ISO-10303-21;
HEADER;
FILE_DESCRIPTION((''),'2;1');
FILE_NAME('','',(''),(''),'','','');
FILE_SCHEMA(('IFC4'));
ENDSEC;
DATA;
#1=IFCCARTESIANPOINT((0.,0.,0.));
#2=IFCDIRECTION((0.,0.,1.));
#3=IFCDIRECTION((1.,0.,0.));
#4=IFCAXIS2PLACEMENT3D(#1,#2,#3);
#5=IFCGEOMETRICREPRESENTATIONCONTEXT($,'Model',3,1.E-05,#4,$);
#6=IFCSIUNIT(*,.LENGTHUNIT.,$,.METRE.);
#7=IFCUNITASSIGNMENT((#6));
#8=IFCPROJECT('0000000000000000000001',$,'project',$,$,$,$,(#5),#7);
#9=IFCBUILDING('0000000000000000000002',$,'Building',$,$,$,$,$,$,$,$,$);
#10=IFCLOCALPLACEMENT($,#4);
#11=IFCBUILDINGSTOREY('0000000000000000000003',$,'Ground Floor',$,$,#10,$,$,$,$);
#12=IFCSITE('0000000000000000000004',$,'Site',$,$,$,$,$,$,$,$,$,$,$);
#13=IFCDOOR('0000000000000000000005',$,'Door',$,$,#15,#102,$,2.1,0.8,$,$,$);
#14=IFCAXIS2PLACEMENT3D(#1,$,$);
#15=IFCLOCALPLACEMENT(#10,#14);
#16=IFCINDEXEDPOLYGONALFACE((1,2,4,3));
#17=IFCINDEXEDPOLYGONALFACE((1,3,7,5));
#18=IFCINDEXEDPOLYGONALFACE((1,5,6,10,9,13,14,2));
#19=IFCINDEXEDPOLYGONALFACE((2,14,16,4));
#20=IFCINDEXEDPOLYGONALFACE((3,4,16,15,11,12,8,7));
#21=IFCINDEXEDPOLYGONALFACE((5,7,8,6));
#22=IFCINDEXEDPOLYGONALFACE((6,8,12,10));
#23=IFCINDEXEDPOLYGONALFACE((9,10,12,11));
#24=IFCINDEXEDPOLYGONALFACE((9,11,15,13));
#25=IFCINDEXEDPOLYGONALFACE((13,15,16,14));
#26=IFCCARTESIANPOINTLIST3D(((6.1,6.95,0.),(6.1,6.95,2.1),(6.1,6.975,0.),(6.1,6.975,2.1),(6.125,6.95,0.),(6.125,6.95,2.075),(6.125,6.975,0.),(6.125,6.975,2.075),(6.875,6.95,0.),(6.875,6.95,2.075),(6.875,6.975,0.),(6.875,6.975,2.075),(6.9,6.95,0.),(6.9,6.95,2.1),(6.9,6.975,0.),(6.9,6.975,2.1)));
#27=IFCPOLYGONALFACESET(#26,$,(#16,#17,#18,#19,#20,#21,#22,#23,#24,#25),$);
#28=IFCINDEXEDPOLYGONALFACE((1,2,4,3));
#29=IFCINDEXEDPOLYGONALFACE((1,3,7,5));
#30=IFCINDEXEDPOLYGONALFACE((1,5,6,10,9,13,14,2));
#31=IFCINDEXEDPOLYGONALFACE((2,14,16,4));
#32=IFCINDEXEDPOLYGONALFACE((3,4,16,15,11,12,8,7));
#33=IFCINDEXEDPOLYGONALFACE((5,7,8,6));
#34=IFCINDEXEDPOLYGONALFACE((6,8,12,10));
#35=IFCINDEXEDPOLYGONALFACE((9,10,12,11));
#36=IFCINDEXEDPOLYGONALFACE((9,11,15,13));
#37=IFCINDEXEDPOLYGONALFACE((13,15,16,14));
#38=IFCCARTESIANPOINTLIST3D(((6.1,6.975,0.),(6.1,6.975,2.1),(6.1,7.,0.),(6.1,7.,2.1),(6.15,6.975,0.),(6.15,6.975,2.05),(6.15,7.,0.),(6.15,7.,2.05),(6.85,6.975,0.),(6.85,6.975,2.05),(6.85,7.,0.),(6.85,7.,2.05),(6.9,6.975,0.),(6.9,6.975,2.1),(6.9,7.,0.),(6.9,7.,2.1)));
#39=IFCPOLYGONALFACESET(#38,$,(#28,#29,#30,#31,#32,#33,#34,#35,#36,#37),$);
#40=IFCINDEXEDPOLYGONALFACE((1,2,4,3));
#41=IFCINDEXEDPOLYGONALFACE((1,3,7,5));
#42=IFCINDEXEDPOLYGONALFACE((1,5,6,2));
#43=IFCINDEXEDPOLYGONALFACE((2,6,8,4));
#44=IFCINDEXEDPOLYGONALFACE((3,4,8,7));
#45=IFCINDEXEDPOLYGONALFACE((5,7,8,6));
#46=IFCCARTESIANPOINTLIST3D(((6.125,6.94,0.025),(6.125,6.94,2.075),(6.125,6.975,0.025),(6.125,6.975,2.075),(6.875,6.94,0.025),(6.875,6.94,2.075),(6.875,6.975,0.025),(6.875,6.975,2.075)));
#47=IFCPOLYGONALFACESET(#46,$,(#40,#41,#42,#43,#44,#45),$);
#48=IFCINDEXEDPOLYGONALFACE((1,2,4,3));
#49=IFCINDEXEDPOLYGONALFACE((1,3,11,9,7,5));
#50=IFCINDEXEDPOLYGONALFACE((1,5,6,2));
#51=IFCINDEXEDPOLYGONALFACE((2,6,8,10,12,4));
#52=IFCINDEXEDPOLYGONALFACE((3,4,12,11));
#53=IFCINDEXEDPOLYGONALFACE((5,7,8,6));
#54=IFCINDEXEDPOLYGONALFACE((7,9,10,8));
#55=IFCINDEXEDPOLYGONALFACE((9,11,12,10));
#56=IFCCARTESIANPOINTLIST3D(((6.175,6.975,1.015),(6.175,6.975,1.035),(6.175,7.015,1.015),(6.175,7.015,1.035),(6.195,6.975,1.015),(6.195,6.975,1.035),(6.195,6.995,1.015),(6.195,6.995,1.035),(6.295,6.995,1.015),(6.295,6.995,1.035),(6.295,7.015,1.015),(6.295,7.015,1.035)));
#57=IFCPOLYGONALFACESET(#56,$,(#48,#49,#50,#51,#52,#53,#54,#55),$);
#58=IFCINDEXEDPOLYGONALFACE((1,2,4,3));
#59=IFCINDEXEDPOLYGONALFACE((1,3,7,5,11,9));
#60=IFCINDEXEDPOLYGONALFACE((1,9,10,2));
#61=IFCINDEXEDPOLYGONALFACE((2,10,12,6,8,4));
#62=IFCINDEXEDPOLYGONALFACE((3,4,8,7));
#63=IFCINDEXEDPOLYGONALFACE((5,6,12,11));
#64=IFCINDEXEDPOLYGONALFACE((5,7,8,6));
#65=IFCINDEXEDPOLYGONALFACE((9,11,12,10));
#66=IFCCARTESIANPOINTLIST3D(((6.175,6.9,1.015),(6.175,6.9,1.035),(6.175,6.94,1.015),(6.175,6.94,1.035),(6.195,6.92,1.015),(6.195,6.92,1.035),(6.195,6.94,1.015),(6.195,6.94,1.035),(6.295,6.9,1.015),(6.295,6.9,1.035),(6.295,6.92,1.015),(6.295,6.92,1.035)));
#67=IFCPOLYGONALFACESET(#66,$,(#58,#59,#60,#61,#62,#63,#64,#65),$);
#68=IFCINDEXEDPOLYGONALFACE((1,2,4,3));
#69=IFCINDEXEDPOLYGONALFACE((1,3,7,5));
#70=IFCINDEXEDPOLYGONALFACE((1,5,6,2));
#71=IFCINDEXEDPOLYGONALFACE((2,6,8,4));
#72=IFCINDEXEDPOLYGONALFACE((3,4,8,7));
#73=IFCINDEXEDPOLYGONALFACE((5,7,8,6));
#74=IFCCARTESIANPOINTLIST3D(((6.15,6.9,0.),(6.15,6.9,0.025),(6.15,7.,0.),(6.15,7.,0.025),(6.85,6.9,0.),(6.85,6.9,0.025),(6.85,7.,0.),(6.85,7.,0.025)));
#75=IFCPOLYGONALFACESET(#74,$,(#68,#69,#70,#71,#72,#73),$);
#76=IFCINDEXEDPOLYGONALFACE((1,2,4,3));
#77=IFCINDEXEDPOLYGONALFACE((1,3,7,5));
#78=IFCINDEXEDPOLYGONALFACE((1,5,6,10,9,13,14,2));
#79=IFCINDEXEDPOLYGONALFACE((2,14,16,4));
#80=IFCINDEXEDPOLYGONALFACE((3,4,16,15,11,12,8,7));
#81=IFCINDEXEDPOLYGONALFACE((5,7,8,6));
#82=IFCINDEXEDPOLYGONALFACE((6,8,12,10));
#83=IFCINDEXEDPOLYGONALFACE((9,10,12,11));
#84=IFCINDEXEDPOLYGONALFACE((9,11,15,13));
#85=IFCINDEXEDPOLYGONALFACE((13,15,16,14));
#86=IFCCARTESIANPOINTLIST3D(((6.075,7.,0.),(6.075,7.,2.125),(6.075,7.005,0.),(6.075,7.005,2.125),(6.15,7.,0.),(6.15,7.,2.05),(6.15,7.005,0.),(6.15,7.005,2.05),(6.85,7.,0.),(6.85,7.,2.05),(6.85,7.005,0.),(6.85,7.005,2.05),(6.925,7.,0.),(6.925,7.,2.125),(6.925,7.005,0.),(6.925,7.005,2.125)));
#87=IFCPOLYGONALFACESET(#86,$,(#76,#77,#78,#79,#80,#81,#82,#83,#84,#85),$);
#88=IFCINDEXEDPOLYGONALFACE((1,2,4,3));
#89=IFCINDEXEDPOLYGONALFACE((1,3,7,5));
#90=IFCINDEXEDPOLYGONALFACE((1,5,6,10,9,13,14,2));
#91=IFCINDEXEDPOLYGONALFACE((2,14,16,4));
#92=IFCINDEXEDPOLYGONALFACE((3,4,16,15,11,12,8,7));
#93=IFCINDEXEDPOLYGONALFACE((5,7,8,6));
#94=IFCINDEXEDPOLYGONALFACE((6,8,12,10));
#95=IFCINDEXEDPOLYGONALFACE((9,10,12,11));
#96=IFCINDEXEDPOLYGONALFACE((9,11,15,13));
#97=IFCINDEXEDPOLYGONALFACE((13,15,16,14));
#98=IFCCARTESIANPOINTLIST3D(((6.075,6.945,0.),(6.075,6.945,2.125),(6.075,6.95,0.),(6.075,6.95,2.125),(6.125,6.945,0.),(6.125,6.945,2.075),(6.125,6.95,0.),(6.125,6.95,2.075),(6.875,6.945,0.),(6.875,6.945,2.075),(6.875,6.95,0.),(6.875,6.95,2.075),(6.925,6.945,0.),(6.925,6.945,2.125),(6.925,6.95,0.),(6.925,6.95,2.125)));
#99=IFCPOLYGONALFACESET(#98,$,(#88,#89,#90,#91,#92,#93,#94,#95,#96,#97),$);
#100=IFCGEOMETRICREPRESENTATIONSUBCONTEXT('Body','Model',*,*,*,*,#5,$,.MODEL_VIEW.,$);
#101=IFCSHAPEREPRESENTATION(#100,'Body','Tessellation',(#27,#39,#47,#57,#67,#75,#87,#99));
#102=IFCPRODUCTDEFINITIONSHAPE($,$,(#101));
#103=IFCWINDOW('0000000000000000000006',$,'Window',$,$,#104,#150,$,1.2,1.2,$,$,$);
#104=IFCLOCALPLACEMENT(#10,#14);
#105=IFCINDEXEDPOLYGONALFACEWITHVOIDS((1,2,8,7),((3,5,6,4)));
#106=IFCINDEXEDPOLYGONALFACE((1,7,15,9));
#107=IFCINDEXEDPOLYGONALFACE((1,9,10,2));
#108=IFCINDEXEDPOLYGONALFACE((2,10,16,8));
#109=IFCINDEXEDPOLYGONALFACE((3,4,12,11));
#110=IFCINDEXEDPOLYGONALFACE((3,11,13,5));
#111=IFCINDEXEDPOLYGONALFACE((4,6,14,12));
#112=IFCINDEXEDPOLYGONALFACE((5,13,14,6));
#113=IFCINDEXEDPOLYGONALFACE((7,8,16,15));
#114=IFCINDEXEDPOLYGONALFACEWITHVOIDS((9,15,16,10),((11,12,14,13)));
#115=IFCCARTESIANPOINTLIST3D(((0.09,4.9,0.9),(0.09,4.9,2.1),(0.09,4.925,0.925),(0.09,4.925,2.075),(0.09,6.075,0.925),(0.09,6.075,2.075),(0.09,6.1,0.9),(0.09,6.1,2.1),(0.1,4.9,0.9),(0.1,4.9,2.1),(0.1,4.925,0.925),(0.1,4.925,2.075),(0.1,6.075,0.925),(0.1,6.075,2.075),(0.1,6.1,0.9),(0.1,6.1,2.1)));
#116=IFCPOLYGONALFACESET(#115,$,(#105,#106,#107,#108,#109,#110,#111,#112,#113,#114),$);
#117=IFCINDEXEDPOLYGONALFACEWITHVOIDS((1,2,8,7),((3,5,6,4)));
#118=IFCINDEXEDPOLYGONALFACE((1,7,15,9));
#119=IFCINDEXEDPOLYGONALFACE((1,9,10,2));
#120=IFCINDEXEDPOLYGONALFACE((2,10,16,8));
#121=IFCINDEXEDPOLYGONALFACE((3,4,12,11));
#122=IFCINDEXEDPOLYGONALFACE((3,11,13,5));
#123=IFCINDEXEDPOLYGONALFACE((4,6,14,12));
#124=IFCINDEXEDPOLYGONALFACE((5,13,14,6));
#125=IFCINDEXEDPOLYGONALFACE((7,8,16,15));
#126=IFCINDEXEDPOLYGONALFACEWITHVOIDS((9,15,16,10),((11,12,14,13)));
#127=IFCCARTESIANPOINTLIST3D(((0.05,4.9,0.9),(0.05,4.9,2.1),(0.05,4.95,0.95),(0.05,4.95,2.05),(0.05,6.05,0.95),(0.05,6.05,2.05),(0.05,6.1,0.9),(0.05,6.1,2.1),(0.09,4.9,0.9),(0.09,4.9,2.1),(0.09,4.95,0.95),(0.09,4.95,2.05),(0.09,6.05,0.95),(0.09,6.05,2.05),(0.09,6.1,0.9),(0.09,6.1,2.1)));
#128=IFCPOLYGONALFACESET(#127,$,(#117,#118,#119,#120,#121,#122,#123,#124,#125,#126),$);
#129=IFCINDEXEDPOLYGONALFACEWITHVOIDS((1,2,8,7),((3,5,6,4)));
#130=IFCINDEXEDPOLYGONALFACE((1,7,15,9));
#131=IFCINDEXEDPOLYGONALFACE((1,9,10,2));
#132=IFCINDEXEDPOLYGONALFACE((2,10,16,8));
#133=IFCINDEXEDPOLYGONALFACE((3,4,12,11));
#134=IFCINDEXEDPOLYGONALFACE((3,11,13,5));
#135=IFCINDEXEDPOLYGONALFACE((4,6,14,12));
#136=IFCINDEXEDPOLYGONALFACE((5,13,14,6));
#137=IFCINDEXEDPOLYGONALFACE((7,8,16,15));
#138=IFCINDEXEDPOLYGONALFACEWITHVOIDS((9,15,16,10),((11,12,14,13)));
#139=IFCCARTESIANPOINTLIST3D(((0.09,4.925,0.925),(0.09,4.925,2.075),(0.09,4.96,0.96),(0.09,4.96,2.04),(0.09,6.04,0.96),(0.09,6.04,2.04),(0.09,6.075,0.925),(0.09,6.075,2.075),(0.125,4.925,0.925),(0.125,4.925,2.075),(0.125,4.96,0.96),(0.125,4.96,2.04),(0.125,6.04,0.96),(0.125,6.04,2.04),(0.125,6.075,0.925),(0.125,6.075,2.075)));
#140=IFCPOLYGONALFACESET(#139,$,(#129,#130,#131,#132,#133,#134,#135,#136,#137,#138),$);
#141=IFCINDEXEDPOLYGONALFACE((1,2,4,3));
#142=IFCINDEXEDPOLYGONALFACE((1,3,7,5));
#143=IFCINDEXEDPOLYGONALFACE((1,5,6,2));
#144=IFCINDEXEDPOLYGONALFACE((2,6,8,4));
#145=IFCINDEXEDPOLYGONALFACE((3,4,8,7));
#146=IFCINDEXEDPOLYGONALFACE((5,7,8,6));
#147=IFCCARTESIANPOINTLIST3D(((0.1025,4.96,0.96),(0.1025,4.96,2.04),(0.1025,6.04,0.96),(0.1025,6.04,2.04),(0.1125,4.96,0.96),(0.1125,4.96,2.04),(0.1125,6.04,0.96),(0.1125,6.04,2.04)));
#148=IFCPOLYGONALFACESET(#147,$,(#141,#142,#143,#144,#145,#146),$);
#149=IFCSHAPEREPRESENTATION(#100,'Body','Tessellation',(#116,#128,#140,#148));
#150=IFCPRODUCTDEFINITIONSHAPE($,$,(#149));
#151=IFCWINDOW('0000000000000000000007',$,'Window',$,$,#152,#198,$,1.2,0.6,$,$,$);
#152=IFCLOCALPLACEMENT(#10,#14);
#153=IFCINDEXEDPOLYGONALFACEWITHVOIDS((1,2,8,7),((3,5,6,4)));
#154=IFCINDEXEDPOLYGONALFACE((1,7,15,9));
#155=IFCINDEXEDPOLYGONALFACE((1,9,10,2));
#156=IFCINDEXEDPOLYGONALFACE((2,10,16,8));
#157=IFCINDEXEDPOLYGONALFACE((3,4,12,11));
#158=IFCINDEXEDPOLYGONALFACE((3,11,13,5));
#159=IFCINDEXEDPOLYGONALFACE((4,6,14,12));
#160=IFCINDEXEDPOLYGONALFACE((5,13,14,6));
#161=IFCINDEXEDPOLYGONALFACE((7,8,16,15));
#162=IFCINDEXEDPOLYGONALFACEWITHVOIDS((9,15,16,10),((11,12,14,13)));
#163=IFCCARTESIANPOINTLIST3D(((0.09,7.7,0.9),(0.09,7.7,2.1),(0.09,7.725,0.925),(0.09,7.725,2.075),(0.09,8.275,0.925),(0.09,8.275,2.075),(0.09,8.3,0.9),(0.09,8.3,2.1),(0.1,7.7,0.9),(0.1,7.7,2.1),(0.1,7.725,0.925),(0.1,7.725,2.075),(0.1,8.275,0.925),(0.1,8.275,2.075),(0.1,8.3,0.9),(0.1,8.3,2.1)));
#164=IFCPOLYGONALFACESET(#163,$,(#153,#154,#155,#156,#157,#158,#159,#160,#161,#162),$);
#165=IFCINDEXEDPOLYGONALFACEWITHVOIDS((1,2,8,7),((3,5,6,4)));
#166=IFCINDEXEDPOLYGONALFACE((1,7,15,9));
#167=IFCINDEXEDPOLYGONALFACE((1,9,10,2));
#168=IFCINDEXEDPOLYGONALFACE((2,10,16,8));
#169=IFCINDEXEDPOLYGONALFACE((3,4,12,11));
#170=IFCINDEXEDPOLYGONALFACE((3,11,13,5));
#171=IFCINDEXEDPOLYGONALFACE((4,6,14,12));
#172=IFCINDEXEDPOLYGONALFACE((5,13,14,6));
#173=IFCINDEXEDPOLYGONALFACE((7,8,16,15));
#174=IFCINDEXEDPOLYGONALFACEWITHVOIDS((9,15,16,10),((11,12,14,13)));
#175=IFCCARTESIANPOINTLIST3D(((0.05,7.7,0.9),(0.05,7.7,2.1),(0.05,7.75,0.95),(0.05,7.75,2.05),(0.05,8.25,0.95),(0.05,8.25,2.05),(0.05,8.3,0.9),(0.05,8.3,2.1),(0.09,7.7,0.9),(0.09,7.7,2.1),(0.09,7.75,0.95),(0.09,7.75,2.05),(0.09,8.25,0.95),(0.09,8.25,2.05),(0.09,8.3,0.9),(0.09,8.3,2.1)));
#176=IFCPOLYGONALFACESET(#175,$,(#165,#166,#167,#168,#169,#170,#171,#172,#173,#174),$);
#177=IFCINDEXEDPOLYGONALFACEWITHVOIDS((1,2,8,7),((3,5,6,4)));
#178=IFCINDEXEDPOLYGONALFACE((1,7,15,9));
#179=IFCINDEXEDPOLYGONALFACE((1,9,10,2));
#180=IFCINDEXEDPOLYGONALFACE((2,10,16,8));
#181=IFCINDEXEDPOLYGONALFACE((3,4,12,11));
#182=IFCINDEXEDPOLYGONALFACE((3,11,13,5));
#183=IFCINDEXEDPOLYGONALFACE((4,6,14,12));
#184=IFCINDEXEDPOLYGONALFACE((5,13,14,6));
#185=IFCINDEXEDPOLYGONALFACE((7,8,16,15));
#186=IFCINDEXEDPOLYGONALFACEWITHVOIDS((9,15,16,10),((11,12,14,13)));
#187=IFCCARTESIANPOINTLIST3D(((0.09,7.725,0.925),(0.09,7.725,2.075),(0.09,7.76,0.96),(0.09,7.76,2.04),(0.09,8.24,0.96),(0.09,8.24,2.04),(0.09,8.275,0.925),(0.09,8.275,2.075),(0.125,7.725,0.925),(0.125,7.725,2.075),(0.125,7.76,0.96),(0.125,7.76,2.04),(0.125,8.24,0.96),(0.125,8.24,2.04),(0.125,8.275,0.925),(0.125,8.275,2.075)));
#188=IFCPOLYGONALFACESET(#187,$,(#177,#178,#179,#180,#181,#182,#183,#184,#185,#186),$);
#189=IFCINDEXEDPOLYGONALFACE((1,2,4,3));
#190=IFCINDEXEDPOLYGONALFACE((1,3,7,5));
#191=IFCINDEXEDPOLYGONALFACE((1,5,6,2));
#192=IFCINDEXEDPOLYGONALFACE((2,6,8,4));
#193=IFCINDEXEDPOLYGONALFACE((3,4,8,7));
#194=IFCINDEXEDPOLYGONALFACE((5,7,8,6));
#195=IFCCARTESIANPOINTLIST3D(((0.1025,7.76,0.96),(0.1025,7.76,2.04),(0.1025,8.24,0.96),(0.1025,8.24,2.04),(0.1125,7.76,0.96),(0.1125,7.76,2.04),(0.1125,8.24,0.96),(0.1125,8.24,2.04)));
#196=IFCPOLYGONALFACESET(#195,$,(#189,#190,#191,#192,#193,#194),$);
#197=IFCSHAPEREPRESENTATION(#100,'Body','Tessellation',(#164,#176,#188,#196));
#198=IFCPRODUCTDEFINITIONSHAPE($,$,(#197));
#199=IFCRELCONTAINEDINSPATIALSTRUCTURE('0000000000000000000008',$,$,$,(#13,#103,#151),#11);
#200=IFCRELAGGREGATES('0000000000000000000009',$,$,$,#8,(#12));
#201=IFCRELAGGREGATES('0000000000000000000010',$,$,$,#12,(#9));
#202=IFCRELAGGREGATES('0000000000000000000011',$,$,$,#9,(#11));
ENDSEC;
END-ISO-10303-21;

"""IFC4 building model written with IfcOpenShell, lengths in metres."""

from ifc_helpers import new_model, si_unit, frame, origin_with_axes, place, context, subcontext, project, spatial, line, indexed_curve, outline, extrude, element, save


model = new_model("IFC4")

# Units and contexts
model_context = context("Model", 3, precision=1e-05, world=origin_with_axes())
body_context = subcontext(model_context, "Body", "Model", "MODEL_VIEW")
ifc_project = project(units=[si_unit("LENGTHUNIT", "METRE")], contexts=[model_context])

# Site, building, storey
site = spatial("IfcSite", under=ifc_project, Name="Site")
building = spatial("IfcBuilding", under=site, Name="Building")
storey_placement = place(None, origin_with_axes())
storey = spatial("IfcBuildingStorey", under=building, at=storey_placement, Name="Ground Floor")

# Door
door_1_placement = place(storey_placement, frame((6.9, 7.0, 0.0), z_axis=(0.0, 0.0, 1.0), x_axis=(-1.0, 0.0, 0.0)))
element("IfcDoor", 1, at=door_1_placement, inside=storey, Name="Door", OverallHeight=2.1, OverallWidth=0.8, context=body_context, shape_type="SweptSolid", body=[
    extrude(outline(indexed_curve([(0.0, 0.0), (0.0, 2.1), (0.8, 2.1), (0.8, 0.0), (0.775, 0.0), (0.775, 2.075), (0.025, 2.075), (0.025, 0.0)], segments=[line(1, 2, 3, 4, 5, 6, 7, 8, 1)])), frame((0.0, 0.025, 0.0), z_axis=(0.0, -1.0, 0.0), x_axis=(1.0, 0.0, 0.0)), (0.0, 0.0, -1.0), 0.025),
    extrude(outline(indexed_curve([(0.0, 0.0), (0.0, 2.1), (0.8, 2.1), (0.8, 0.0), (0.75, 0.0), (0.75, 2.05), (0.05, 2.05), (0.05, 0.0)], segments=[line(1, 2, 3, 4, 5, 6, 7, 8, 1)])), frame((0.0, 0.0, 0.0), z_axis=(0.0, -1.0, 0.0), x_axis=(1.0, 0.0, 0.0)), (0.0, 0.0, -1.0), 0.025),
    extrude(outline(indexed_curve([(0.0, 0.0), (0.75, 0.0), (0.75, 0.035), (0.0, 0.035)], segments=[line(1, 2, 3, 4, 1)])), frame((0.025, 0.025, 0.025), z_axis=(0.0, 0.0, 1.0), x_axis=(1.0, 0.0, 0.0)), (0.0, 0.0, 1.0), 2.05),
    extrude(outline(indexed_curve([(0.0, 0.0), (0.0, -0.04), (-0.12, -0.04), (-0.12, -0.02), (-0.02, -0.02), (-0.02, 0.0)], segments=[line(1, 2, 3, 4, 5, 6, 1)])), frame((0.725, 0.025, 1.015), z_axis=(0.0, 0.0, 1.0), x_axis=(1.0, 0.0, 0.0)), (0.0, 0.0, 1.0), 0.02),
    extrude(outline(indexed_curve([(0.0, 0.0), (0.0, 0.04), (-0.12, 0.04), (-0.12, 0.02), (-0.02, 0.02), (-0.02, 0.0)], segments=[line(1, 2, 3, 4, 5, 6, 1)])), frame((0.725, 0.06, 1.015), z_axis=(0.0, 0.0, 1.0), x_axis=(1.0, 0.0, 0.0)), (0.0, 0.0, 1.0), 0.02),
    extrude(outline(indexed_curve([(0.0, 0.0), (0.7, 0.0), (0.7, 0.1), (0.0, 0.1)], segments=[line(1, 2, 3, 4, 1)])), frame((0.05, 0.0, 0.0), z_axis=(0.0, 0.0, 1.0), x_axis=(1.0, 0.0, 0.0)), (0.0, 0.0, 1.0), 0.025),
    extrude(outline(indexed_curve([(0.0, 0.0), (0.0, 2.125), (0.85, 2.125), (0.85, 0.0), (0.775, 0.0), (0.775, 2.05), (0.075, 2.05), (0.075, 0.0)], segments=[line(1, 2, 3, 4, 5, 6, 7, 8, 1)])), frame((-0.025, -0.005, 0.0), z_axis=(0.0, -1.0, 0.0), x_axis=(1.0, 0.0, 0.0)), (0.0, 0.0, -1.0), 0.005),
    extrude(outline(indexed_curve([(0.0, 0.0), (0.0, 2.125), (0.85, 2.125), (0.85, 0.0), (0.8, 0.0), (0.8, 2.075), (0.05, 2.075), (0.05, 0.0)], segments=[line(1, 2, 3, 4, 5, 6, 7, 8, 1)])), frame((-0.025, 0.05, 0.0), z_axis=(0.0, -1.0, 0.0), x_axis=(1.0, 0.0, 0.0)), (0.0, 0.0, -1.0), 0.005),
])

# Windows
window_1_placement = place(storey_placement, frame((0.0, 6.1, 0.9), z_axis=(0.0, 0.0, 1.0), x_axis=(0.0, -1.0, 0.0)))
element("IfcWindow", 2, at=window_1_placement, inside=storey, Name="Window", OverallHeight=1.2, OverallWidth=1.2, context=body_context, shape_type="SweptSolid", body=[
    extrude(outline(indexed_curve([(0.0, 0.0), (1.2, 0.0), (1.2, 1.2), (0.0, 1.2)], segments=[line(1, 2, 3, 4, 1)]), holes=[indexed_curve([(0.025, 0.025), (1.175, 0.025), (1.175, 1.175), (0.025, 1.175)], segments=[line(1, 2, 3, 4, 1)])]), frame((0.0, 0.09, 0.0), z_axis=(0.0, -1.0, 0.0), x_axis=(1.0, 0.0, 0.0)), (0.0, 0.0, -1.0), 0.01),
    extrude(outline(indexed_curve([(0.0, 0.0), (1.2, 0.0), (1.2, 1.2), (0.0, 1.2)], segments=[line(1, 2, 3, 4, 1)]), holes=[indexed_curve([(0.05, 0.05), (1.15, 0.05), (1.15, 1.15), (0.05, 1.15)], segments=[line(1, 2, 3, 4, 1)])]), frame((0.0, 0.05, 0.0), z_axis=(0.0, -1.0, 0.0), x_axis=(1.0, 0.0, 0.0)), (0.0, 0.0, -1.0), 0.04),
    extrude(outline(indexed_curve([(0.0, 0.0), (1.15, 0.0), (1.15, 1.15), (0.0, 1.15)], segments=[line(1, 2, 3, 4, 1)]), holes=[indexed_curve([(0.035, 0.035), (1.115, 0.035), (1.115, 1.115), (0.035, 1.115)], segments=[line(1, 2, 3, 4, 1)])]), frame((0.025, 0.09, 0.025), z_axis=(0.0, -1.0, 0.0), x_axis=(1.0, 0.0, 0.0)), (0.0, 0.0, -1.0), 0.035),
    extrude(outline(indexed_curve([(0.035, 0.035), (1.115, 0.035), (1.115, 1.115), (0.035, 1.115)], segments=[line(1, 2, 3, 4, 1)])), frame((0.025, 0.1025, 0.025), z_axis=(0.0, -1.0, 0.0), x_axis=(1.0, 0.0, 0.0)), (0.0, 0.0, -1.0), 0.01),
])
window_2_placement = place(storey_placement, frame((0.0, 8.3, 0.9), z_axis=(0.0, 0.0, 1.0), x_axis=(0.0, -1.0, 0.0)))
element("IfcWindow", 3, at=window_2_placement, inside=storey, Name="Window", OverallHeight=1.2, OverallWidth=0.6, context=body_context, shape_type="SweptSolid", body=[
    extrude(outline(indexed_curve([(0.0, 0.0), (0.6, 0.0), (0.6, 1.2), (0.0, 1.2)], segments=[line(1, 2, 3, 4, 1)]), holes=[indexed_curve([(0.025, 0.025), (0.575, 0.025), (0.575, 1.175), (0.025, 1.175)], segments=[line(1, 2, 3, 4, 1)])]), frame((0.0, 0.09, 0.0), z_axis=(0.0, -1.0, 0.0), x_axis=(1.0, 0.0, 0.0)), (0.0, 0.0, -1.0), 0.01),
    extrude(outline(indexed_curve([(0.0, 0.0), (0.6, 0.0), (0.6, 1.2), (0.0, 1.2)], segments=[line(1, 2, 3, 4, 1)]), holes=[indexed_curve([(0.05, 0.05), (0.55, 0.05), (0.55, 1.15), (0.05, 1.15)], segments=[line(1, 2, 3, 4, 1)])]), frame((0.0, 0.05, 0.0), z_axis=(0.0, -1.0, 0.0), x_axis=(1.0, 0.0, 0.0)), (0.0, 0.0, -1.0), 0.04),
    extrude(outline(indexed_curve([(0.0, 0.0), (0.55, 0.0), (0.55, 1.15), (0.0, 1.15)], segments=[line(1, 2, 3, 4, 1)]), holes=[indexed_curve([(0.035, 0.035), (0.515, 0.035), (0.515, 1.115), (0.035, 1.115)], segments=[line(1, 2, 3, 4, 1)])]), frame((0.025, 0.09, 0.025), z_axis=(0.0, -1.0, 0.0), x_axis=(1.0, 0.0, 0.0)), (0.0, 0.0, -1.0), 0.035),
    extrude(outline(indexed_curve([(0.035, 0.035), (0.515, 0.035), (0.515, 1.115), (0.035, 1.115)], segments=[line(1, 2, 3, 4, 1)])), frame((0.025, 0.1025, 0.025), z_axis=(0.0, -1.0, 0.0), x_axis=(1.0, 0.0, 0.0)), (0.0, 0.0, -1.0), 0.01),
])

save(model, "model.ifc")
